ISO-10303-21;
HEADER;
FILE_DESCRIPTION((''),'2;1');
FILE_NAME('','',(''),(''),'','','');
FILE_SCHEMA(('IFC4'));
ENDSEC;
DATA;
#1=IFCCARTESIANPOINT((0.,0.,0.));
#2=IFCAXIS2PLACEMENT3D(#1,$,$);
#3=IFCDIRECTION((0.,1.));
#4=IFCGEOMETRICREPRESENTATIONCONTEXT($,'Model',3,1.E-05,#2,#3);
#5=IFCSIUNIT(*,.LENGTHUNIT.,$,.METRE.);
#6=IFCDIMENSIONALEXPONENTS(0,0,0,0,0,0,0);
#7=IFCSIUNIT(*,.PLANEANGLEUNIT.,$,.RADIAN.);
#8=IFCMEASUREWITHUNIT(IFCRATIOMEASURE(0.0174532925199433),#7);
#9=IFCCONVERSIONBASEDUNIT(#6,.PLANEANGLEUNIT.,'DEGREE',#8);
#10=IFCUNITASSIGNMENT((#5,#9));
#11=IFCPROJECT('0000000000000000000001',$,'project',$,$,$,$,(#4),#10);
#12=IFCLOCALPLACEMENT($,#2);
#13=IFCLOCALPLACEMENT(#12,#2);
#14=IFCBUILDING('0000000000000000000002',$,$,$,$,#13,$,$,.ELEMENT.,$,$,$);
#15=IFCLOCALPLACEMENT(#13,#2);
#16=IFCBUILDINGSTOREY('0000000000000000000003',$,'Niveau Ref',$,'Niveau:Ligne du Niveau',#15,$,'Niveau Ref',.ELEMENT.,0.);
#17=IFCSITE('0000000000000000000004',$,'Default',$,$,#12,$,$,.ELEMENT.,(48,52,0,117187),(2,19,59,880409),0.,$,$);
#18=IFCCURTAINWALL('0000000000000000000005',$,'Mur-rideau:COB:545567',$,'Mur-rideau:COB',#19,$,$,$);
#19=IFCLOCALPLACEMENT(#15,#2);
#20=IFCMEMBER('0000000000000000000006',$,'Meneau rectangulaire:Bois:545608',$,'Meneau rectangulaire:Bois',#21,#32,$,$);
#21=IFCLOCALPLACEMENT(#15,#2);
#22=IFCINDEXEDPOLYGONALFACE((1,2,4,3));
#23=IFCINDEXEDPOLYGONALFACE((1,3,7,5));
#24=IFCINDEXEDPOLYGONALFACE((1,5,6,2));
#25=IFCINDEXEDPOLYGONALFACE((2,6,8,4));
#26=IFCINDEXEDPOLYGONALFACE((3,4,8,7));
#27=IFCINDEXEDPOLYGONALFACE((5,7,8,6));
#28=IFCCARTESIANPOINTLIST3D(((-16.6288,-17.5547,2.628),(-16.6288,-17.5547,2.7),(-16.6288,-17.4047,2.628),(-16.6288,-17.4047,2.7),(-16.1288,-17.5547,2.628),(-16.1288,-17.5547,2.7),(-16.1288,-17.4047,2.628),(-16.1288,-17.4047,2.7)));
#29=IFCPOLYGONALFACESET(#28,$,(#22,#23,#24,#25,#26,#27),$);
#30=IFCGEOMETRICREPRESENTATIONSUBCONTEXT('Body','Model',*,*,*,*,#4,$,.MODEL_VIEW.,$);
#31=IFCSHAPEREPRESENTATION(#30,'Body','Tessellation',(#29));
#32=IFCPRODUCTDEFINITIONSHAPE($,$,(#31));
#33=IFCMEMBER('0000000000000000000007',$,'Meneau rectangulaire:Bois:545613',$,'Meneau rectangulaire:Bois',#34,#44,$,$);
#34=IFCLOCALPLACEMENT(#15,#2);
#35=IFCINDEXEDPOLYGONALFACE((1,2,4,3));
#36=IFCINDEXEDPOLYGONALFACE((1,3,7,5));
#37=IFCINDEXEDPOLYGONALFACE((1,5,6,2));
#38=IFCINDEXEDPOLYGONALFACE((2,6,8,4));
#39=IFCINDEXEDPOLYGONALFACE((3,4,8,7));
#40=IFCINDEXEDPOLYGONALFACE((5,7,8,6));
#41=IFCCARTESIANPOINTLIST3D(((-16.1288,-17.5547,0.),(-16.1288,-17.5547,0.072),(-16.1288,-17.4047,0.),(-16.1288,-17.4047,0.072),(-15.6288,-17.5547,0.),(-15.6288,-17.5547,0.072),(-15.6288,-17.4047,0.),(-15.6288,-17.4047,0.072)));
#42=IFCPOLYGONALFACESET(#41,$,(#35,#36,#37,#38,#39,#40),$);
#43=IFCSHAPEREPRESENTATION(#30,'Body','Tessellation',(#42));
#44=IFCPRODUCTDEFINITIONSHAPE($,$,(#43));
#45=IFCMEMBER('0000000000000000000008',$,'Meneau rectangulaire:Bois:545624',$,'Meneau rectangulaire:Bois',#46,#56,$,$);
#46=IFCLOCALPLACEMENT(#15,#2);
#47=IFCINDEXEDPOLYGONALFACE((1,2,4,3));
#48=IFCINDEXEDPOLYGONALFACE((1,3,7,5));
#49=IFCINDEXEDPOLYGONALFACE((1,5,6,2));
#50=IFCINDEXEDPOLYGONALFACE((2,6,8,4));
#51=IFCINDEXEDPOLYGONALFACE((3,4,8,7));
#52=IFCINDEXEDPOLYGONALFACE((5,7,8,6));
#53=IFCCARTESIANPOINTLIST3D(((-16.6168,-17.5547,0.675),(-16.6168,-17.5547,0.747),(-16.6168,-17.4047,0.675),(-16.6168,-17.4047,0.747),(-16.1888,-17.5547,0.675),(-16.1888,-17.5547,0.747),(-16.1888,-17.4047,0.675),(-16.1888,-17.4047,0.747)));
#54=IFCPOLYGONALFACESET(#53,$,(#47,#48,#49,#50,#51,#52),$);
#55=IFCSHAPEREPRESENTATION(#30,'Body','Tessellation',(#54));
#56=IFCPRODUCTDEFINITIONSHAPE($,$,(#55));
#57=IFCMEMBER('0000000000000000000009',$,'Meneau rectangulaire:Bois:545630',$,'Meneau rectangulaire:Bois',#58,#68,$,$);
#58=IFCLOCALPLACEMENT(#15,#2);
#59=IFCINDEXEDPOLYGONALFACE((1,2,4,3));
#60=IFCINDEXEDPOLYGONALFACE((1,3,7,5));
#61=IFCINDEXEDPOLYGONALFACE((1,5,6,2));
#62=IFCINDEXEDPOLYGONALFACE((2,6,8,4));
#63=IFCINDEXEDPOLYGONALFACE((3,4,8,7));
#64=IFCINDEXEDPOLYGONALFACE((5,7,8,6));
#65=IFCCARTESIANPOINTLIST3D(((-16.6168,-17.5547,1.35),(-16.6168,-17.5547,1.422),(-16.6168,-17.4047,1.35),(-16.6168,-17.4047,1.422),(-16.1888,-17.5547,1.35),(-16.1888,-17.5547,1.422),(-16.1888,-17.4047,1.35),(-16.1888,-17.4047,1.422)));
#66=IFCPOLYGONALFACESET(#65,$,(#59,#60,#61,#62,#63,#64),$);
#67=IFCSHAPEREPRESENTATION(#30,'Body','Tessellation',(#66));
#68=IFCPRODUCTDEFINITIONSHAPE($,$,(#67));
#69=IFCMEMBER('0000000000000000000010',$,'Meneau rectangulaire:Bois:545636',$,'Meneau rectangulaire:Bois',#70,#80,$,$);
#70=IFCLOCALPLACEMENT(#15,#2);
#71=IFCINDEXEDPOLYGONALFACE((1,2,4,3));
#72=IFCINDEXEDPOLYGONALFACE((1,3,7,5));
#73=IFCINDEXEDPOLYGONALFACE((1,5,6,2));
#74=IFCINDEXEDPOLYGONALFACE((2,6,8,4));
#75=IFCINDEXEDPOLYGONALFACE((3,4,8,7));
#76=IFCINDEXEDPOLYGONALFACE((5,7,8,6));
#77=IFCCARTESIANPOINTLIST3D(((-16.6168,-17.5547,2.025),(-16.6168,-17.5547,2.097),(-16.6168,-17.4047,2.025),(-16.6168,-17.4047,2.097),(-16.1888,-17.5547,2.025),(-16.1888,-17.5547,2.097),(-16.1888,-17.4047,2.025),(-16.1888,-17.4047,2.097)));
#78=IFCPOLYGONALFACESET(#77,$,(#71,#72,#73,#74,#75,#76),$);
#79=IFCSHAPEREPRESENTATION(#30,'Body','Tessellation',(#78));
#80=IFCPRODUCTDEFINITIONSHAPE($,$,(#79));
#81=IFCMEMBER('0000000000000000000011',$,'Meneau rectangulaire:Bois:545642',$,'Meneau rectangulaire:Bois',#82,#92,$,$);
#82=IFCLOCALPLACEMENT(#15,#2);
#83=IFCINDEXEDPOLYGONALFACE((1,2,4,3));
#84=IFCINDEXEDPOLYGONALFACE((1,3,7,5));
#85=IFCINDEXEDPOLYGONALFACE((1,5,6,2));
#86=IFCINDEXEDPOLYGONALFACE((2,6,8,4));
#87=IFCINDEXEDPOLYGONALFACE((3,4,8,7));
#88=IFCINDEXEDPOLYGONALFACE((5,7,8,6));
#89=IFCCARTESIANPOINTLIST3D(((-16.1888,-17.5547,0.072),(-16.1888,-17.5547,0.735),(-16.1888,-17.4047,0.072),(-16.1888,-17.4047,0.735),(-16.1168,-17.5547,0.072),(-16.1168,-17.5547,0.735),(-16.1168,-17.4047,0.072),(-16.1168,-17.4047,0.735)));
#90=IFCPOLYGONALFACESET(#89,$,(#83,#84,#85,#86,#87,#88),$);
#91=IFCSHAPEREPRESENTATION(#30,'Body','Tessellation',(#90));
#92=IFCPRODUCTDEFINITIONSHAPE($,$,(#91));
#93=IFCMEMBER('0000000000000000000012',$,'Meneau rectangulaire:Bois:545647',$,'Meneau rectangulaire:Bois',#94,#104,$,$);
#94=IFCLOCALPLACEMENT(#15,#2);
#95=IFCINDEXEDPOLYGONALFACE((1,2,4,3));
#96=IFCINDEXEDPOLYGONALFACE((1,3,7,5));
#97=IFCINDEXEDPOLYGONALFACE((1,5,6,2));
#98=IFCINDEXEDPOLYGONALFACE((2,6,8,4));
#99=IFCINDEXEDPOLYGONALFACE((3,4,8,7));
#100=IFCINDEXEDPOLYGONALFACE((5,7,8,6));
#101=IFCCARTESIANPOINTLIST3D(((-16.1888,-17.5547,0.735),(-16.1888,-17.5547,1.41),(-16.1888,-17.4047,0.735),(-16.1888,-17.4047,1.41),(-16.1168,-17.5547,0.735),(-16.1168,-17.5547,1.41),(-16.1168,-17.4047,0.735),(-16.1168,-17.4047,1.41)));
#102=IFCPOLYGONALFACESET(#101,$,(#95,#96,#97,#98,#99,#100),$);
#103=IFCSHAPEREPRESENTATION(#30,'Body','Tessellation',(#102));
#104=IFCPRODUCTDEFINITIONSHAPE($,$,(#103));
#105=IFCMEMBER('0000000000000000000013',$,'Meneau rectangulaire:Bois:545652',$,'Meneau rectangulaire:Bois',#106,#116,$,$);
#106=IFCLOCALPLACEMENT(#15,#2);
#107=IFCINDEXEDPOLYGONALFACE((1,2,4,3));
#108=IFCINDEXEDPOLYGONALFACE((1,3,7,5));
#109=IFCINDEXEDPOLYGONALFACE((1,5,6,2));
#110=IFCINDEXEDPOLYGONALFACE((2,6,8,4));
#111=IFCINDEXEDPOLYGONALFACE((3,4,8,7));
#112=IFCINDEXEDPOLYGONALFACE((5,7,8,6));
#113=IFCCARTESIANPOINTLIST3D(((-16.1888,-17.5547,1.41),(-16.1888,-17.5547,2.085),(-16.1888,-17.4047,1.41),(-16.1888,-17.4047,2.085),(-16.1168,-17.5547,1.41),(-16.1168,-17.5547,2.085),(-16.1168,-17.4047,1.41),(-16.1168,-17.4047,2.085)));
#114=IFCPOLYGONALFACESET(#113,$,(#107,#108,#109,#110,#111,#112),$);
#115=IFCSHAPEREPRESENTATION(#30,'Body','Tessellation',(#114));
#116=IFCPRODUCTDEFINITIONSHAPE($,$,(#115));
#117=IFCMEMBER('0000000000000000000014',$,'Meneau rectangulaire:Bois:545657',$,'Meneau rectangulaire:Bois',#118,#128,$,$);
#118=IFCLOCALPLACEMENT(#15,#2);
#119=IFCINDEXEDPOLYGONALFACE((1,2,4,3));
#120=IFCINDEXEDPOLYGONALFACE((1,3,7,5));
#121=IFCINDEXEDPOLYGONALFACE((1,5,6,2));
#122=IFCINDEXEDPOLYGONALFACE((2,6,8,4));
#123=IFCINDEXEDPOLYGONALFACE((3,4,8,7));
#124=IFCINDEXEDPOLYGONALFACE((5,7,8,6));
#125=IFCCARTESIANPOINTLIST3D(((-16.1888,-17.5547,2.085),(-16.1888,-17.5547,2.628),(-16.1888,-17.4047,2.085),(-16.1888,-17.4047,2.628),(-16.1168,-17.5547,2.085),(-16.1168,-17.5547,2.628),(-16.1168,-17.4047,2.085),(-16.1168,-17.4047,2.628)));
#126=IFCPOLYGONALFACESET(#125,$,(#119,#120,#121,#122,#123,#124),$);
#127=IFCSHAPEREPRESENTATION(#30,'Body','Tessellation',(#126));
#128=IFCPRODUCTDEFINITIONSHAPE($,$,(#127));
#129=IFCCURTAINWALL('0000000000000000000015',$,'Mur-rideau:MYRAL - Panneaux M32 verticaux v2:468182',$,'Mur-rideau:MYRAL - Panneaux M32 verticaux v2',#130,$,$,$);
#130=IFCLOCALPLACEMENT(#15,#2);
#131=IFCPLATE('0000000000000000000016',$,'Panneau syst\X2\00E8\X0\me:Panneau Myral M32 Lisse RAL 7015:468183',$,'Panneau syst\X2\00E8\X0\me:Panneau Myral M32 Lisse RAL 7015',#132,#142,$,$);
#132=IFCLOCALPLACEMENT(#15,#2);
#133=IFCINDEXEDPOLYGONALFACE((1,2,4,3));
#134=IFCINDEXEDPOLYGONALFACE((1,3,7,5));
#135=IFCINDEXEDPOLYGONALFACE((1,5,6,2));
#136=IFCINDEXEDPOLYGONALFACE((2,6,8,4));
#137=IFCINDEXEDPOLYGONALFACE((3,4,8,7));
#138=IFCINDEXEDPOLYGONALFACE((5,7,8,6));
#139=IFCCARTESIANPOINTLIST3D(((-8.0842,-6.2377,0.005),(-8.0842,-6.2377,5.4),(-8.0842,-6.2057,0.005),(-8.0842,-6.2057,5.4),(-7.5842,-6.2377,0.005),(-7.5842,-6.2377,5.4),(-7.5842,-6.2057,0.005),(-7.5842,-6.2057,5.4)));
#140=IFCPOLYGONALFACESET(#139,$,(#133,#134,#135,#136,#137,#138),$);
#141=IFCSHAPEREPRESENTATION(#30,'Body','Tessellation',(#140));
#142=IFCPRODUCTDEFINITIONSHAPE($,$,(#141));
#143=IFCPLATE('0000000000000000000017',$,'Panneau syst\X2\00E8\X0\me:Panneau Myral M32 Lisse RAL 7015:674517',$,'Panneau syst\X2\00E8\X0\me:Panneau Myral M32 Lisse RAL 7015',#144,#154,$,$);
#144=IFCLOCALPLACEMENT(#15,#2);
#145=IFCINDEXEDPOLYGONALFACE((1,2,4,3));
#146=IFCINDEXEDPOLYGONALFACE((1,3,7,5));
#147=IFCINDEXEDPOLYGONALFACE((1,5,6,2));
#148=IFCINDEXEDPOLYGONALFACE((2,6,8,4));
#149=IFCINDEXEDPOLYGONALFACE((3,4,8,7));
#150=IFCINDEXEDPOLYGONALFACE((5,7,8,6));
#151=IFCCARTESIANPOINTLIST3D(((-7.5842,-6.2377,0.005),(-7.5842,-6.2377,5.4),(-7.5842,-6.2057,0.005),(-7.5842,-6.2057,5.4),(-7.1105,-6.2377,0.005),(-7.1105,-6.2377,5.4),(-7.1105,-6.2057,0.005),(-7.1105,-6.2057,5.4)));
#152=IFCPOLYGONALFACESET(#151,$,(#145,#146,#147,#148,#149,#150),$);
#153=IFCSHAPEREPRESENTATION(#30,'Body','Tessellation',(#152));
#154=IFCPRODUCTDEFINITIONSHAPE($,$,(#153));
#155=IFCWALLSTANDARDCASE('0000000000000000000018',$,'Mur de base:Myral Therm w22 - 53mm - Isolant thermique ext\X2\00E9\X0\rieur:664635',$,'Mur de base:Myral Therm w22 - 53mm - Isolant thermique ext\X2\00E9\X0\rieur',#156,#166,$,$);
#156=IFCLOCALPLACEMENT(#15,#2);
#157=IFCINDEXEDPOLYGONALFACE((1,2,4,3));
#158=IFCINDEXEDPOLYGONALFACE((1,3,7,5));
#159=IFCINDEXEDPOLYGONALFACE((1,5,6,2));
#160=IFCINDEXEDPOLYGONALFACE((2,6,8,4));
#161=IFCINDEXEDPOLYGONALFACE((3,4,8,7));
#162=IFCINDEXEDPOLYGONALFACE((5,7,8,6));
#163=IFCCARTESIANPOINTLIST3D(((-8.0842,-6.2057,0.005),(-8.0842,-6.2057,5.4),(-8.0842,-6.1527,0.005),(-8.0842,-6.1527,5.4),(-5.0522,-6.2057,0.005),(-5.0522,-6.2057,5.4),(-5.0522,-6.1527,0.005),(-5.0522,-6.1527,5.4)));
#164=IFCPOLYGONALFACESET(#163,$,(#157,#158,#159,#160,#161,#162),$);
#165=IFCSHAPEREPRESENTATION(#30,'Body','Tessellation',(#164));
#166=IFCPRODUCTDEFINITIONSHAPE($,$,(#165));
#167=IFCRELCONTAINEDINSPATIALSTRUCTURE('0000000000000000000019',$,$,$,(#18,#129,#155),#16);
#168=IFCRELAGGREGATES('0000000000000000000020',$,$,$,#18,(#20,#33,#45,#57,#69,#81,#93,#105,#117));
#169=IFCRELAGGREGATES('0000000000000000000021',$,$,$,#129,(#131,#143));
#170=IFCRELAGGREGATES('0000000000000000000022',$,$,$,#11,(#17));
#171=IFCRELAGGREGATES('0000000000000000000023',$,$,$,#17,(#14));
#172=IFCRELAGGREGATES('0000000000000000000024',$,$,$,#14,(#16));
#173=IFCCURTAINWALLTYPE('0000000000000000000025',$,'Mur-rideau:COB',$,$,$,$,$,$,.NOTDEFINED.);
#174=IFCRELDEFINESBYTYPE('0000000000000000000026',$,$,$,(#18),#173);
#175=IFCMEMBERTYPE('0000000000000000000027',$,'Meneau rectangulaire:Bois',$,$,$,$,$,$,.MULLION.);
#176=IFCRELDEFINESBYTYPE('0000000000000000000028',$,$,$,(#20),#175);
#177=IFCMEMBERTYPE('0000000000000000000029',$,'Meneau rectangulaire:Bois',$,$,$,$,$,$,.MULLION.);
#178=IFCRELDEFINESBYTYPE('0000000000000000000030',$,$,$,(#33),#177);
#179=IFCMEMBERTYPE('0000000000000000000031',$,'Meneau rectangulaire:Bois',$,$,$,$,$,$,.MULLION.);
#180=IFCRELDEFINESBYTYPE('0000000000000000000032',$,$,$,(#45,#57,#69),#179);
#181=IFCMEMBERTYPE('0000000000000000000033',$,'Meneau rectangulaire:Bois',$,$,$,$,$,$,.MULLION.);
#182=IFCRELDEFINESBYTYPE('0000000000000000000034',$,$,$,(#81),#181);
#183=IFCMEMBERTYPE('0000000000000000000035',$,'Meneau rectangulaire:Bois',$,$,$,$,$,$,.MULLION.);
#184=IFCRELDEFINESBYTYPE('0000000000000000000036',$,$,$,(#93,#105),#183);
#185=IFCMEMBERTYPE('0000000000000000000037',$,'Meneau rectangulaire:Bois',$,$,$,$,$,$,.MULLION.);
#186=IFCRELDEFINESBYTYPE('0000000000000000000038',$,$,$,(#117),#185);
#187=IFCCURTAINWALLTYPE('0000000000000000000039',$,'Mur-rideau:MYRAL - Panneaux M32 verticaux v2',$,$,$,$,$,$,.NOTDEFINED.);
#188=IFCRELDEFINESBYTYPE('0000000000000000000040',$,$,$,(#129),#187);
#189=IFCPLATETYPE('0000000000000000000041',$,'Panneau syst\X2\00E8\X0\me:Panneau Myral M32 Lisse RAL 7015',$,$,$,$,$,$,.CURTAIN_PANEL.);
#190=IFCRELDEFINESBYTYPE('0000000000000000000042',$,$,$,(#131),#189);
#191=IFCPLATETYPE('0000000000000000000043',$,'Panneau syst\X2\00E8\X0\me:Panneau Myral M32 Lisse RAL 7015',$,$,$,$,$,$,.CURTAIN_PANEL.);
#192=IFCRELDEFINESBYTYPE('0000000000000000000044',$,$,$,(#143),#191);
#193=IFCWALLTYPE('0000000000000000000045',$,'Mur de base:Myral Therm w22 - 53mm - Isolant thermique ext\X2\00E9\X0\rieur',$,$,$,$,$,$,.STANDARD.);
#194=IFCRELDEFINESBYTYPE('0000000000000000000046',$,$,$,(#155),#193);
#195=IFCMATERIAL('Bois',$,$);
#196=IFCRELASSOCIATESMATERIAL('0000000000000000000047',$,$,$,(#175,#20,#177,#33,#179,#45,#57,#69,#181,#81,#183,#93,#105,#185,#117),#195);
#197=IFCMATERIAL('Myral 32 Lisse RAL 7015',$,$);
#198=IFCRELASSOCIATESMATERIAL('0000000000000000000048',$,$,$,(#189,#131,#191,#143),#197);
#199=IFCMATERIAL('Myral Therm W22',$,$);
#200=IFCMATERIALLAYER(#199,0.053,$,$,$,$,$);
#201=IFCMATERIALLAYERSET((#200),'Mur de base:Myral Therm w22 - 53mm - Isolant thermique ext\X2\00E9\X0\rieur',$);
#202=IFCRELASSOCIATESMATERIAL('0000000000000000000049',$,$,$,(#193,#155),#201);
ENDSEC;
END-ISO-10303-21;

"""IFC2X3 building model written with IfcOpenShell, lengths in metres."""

from ifc_helpers import new_model, entity, si_unit, converted_unit, direction, frame, frame_2d, origin, origin_2d_with_axis, place, context, subcontext, project, spatial, rectangle, extrude, source, transform, mapped, material, layer, layer_set, layer_usage, type_object, type_shapes, element, aggregate, save


model = new_model("IFC2X3")

# Units and contexts
model_context = context("Model", 3, precision=1e-05, world=origin(), true_north=direction((0.0, 1.0)))
body_context = subcontext(model_context, "Body", "Model", "MODEL_VIEW")
ifc_project = project(units=[si_unit("LENGTHUNIT", "METRE"), converted_unit("PLANEANGLEUNIT", "DEGREE", entity("IfcRatioMeasure", 0.0174532925199433), si_unit("PLANEANGLEUNIT", "RADIAN"), dimensions=[0, 0, 0, 0, 0, 0, 0])], contexts=[model_context])

# Site, building, storey
site_placement = place(None, origin())
site = spatial("IfcSite", under=ifc_project, at=site_placement, Name="Default", CompositionType="ELEMENT", RefLatitude=(48, 52, 0, 117187), RefLongitude=(2, 19, 59, 880409), RefElevation=0.0)
building_placement = place(site_placement, origin())
building = spatial("IfcBuilding", under=site, at=building_placement, CompositionType="ELEMENT")
storey_placement = place(building_placement, origin())
storey = spatial("IfcBuildingStorey", under=building, at=storey_placement, Name="Niveau Ref", ObjectType="Niveau:Ligne du Niveau", LongName="Niveau Ref", CompositionType="ELEMENT", Elevation=0.0)

# Curtain wall, members
curtain_wall_type_1 = type_object("IfcCurtainWallType", Name="Mur-rideau:COB", PredefinedType="NOTDEFINED")
curtain_wall_1_placement = place(storey_placement, origin())
curtain_wall_1 = element("IfcCurtainWall", 1, at=curtain_wall_1_placement, inside=storey, type_object=curtain_wall_type_1, Name="Mur-rideau:COB:545567", ObjectType="Mur-rideau:COB")
ifc_material_1 = material(Name="Bois")
member_type_1 = type_object("IfcMemberType", Name="Meneau rectangulaire:Bois", PredefinedType="MULLION", material=ifc_material_1)
shared_shape_1 = source(origin(), body_context, "Body", "SweptSolid", [
    extrude(rectangle(XDim=0.15, YDim=0.072, at=origin_2d_with_axis()), frame((-0.036, 0.0, -0.5), z_axis=(0.0, 0.0, 1.0), x_axis=(0.0, -1.0, 0.0)), (0.0, 0.0, 1.0), 0.5),
])
type_shapes(member_type_1, [shared_shape_1])
member_1_placement = place(storey_placement, frame((-16.1288, -17.4797, 2.7), z_axis=(1.0, 0.0, 0.0), x_axis=(0.0, 0.0, 1.0)))
member_1 = element("IfcMember", 2, at=member_1_placement, type_object=member_type_1, material=ifc_material_1, Name="Meneau rectangulaire:Bois:545608", ObjectType="Meneau rectangulaire:Bois", context=body_context, shape_type="MappedRepresentation", body=[
    mapped(shared_shape_1, transform((0.0, 0.0, 0.0), scale=1.0)),
])
member_type_2 = type_object("IfcMemberType", Name="Meneau rectangulaire:Bois", PredefinedType="MULLION", material=ifc_material_1)
shared_shape_2 = source(origin(), body_context, "Body", "SweptSolid", [
    extrude(rectangle(XDim=0.15, YDim=0.072, at=origin_2d_with_axis()), frame((-0.036, 0.0, -0.5), z_axis=(0.0, 0.0, 1.0), x_axis=(0.0, -1.0, 0.0)), (0.0, 0.0, 1.0), 0.5),
])
type_shapes(member_type_2, [shared_shape_2])
member_2_placement = place(storey_placement, frame((-16.1288, -17.4797, 0.0), z_axis=(-1.0, 0.0, 0.0), x_axis=(0.0, 0.0, -1.0)))
member_2 = element("IfcMember", 3, at=member_2_placement, type_object=member_type_2, material=ifc_material_1, Name="Meneau rectangulaire:Bois:545613", ObjectType="Meneau rectangulaire:Bois", context=body_context, shape_type="MappedRepresentation", body=[
    mapped(shared_shape_2, transform((0.0, 0.0, 0.0), scale=1.0)),
])
member_type_3 = type_object("IfcMemberType", Name="Meneau rectangulaire:Bois", PredefinedType="MULLION", material=ifc_material_1)
shared_shape_3 = source(origin(), body_context, "Body", "SweptSolid", [
    extrude(rectangle(XDim=0.15, YDim=0.072, at=origin_2d_with_axis()), frame((-0.024, 0.0, -0.428), z_axis=(0.0, 0.0, 1.0), x_axis=(0.0, -1.0, 0.0)), (0.0, 0.0, 1.0), 0.428),
])
type_shapes(member_type_3, [shared_shape_3])
member_3_placement = place(storey_placement, frame((-16.1888, -17.4797, 0.735), z_axis=(1.0, 0.0, 0.0), x_axis=(0.0, 0.0, 1.0)))
member_3 = element("IfcMember", 4, at=member_3_placement, type_object=member_type_3, material=ifc_material_1, Name="Meneau rectangulaire:Bois:545624", ObjectType="Meneau rectangulaire:Bois", context=body_context, shape_type="MappedRepresentation", body=[
    mapped(shared_shape_3, transform((0.0, 0.0, 0.0), scale=1.0)),
])
member_4_placement = place(storey_placement, frame((-16.1888, -17.4797, 1.41), z_axis=(1.0, 0.0, 0.0), x_axis=(0.0, 0.0, 1.0)))
member_4 = element("IfcMember", 5, at=member_4_placement, type_object=member_type_3, material=ifc_material_1, Name="Meneau rectangulaire:Bois:545630", ObjectType="Meneau rectangulaire:Bois", context=body_context, shape_type="MappedRepresentation", body=[
    mapped(shared_shape_3, transform((0.0, 0.0, 0.0), scale=1.0)),
])
member_5_placement = place(storey_placement, frame((-16.1888, -17.4797, 2.085), z_axis=(1.0, 0.0, 0.0), x_axis=(0.0, 0.0, 1.0)))
member_5 = element("IfcMember", 6, at=member_5_placement, type_object=member_type_3, material=ifc_material_1, Name="Meneau rectangulaire:Bois:545636", ObjectType="Meneau rectangulaire:Bois", context=body_context, shape_type="MappedRepresentation", body=[
    mapped(shared_shape_3, transform((0.0, 0.0, 0.0), scale=1.0)),
])
member_type_4 = type_object("IfcMemberType", Name="Meneau rectangulaire:Bois", PredefinedType="MULLION", material=ifc_material_1)
shared_shape_4 = source(origin(), body_context, "Body", "SweptSolid", [
    extrude(rectangle(XDim=0.15, YDim=0.072, at=origin_2d_with_axis()), frame((-0.024, 0.0, -0.663), z_axis=(0.0, 0.0, 1.0), x_axis=(0.0, -1.0, 0.0)), (0.0, 0.0, 1.0), 0.663),
])
type_shapes(member_type_4, [shared_shape_4])
member_6_placement = place(storey_placement, frame((-16.1288, -17.4797, 0.072), z_axis=(0.0, 0.0, -1.0), x_axis=(1.0, 0.0, 0.0)))
member_6 = element("IfcMember", 7, at=member_6_placement, type_object=member_type_4, material=ifc_material_1, Name="Meneau rectangulaire:Bois:545642", ObjectType="Meneau rectangulaire:Bois", context=body_context, shape_type="MappedRepresentation", body=[
    mapped(shared_shape_4, transform((0.0, 0.0, 0.0), scale=1.0)),
])
member_type_5 = type_object("IfcMemberType", Name="Meneau rectangulaire:Bois", PredefinedType="MULLION", material=ifc_material_1)
shared_shape_5 = source(origin(), body_context, "Body", "SweptSolid", [
    extrude(rectangle(XDim=0.15, YDim=0.072, at=origin_2d_with_axis()), frame((-0.024, 0.0, -0.675), z_axis=(0.0, 0.0, 1.0), x_axis=(0.0, -1.0, 0.0)), (0.0, 0.0, 1.0), 0.675),
])
type_shapes(member_type_5, [shared_shape_5])
member_7_placement = place(storey_placement, frame((-16.1288, -17.4797, 0.735), z_axis=(0.0, 0.0, -1.0), x_axis=(1.0, 0.0, 0.0)))
member_7 = element("IfcMember", 8, at=member_7_placement, type_object=member_type_5, material=ifc_material_1, Name="Meneau rectangulaire:Bois:545647", ObjectType="Meneau rectangulaire:Bois", context=body_context, shape_type="MappedRepresentation", body=[
    mapped(shared_shape_5, transform((0.0, 0.0, 0.0), scale=1.0)),
])
member_8_placement = place(storey_placement, frame((-16.1288, -17.4797, 1.41), z_axis=(0.0, 0.0, -1.0), x_axis=(1.0, 0.0, 0.0)))
member_8 = element("IfcMember", 9, at=member_8_placement, type_object=member_type_5, material=ifc_material_1, Name="Meneau rectangulaire:Bois:545652", ObjectType="Meneau rectangulaire:Bois", context=body_context, shape_type="MappedRepresentation", body=[
    mapped(shared_shape_5, transform((0.0, 0.0, 0.0), scale=1.0)),
])
member_type_6 = type_object("IfcMemberType", Name="Meneau rectangulaire:Bois", PredefinedType="MULLION", material=ifc_material_1)
shared_shape_6 = source(origin(), body_context, "Body", "SweptSolid", [
    extrude(rectangle(XDim=0.15, YDim=0.072, at=origin_2d_with_axis()), frame((-0.024, 0.0, -0.543), z_axis=(0.0, 0.0, 1.0), x_axis=(0.0, -1.0, 0.0)), (0.0, 0.0, 1.0), 0.543),
])
type_shapes(member_type_6, [shared_shape_6])
member_9_placement = place(storey_placement, frame((-16.1288, -17.4797, 2.085), z_axis=(0.0, 0.0, -1.0), x_axis=(1.0, 0.0, 0.0)))
member_9 = element("IfcMember", 10, at=member_9_placement, type_object=member_type_6, material=ifc_material_1, Name="Meneau rectangulaire:Bois:545657", ObjectType="Meneau rectangulaire:Bois", context=body_context, shape_type="MappedRepresentation", body=[
    mapped(shared_shape_6, transform((0.0, 0.0, 0.0), scale=1.0)),
])
aggregate(curtain_wall_1, [member_1, member_2, member_3, member_4, member_5, member_6, member_7, member_8, member_9])

# Curtain wall, plates
curtain_wall_type_2 = type_object("IfcCurtainWallType", Name="Mur-rideau:MYRAL - Panneaux M32 verticaux v2", PredefinedType="NOTDEFINED")
curtain_wall_2_placement = place(storey_placement, origin())
curtain_wall_2 = element("IfcCurtainWall", 11, at=curtain_wall_2_placement, inside=storey, type_object=curtain_wall_type_2, Name="Mur-rideau:MYRAL - Panneaux M32 verticaux v2:468182", ObjectType="Mur-rideau:MYRAL - Panneaux M32 verticaux v2")
ifc_material_2 = material(Name="Myral 32 Lisse RAL 7015")
plate_type_1 = type_object("IfcPlateType", Name="Panneau système:Panneau Myral M32 Lisse RAL 7015", PredefinedType="CURTAIN_PANEL", material=ifc_material_2)
shared_shape_7 = source(origin(), body_context, "Body", "SweptSolid", [
    extrude(rectangle(XDim=0.032, YDim=0.5, at=origin_2d_with_axis()), frame((0.0, -0.016, 0.0), z_axis=(0.0, 0.0, 1.0), x_axis=(0.0, 1.0, 0.0)), (0.0, 0.0, 1.0), 5.395),
])
type_shapes(plate_type_1, [shared_shape_7])
plate_1_placement = place(curtain_wall_2_placement, frame((-7.8342, -6.2057, 0.005)))
plate_1 = element("IfcPlate", 12, at=plate_1_placement, type_object=plate_type_1, material=ifc_material_2, Name="Panneau système:Panneau Myral M32 Lisse RAL 7015:468183", ObjectType="Panneau système:Panneau Myral M32 Lisse RAL 7015", context=body_context, shape_type="MappedRepresentation", body=[
    mapped(shared_shape_7, transform((0.0, 0.0, 0.0), scale=1.0)),
])
plate_type_2 = type_object("IfcPlateType", Name="Panneau système:Panneau Myral M32 Lisse RAL 7015", PredefinedType="CURTAIN_PANEL", material=ifc_material_2)
shared_shape_8 = source(origin(), body_context, "Body", "SweptSolid", [
    extrude(rectangle(XDim=0.032, YDim=0.4737, at=origin_2d_with_axis()), frame((0.0, -0.016, 0.0), z_axis=(0.0, 0.0, 1.0), x_axis=(0.0, 1.0, 0.0)), (0.0, 0.0, 1.0), 5.395),
])
type_shapes(plate_type_2, [shared_shape_8])
plate_2_placement = place(curtain_wall_2_placement, frame((-7.3474, -6.2057, 0.005)))
plate_2 = element("IfcPlate", 13, at=plate_2_placement, type_object=plate_type_2, material=ifc_material_2, Name="Panneau système:Panneau Myral M32 Lisse RAL 7015:674517", ObjectType="Panneau système:Panneau Myral M32 Lisse RAL 7015", context=body_context, shape_type="MappedRepresentation", body=[
    mapped(shared_shape_8, transform((0.0, 0.0, 0.0), scale=1.0)),
])
aggregate(curtain_wall_2, [plate_1, plate_2])

# Wall
ifc_material_3 = material(Name="Myral Therm W22")
ifc_layer = layer(ifc_material_3, 0.053)
ifc_layer_set = layer_set([ifc_layer], Name="Mur de base:Myral Therm w22 - 53mm - Isolant thermique extérieur")
ifc_layer_usage = layer_usage(ifc_layer_set, "AXIS2", "NEGATIVE", 0.0265)
wall_type = type_object("IfcWallType", Name="Mur de base:Myral Therm w22 - 53mm - Isolant thermique extérieur", PredefinedType="STANDARD", material=ifc_layer_set)
wall_placement = place(storey_placement, frame((-8.0842, -6.1792, 0.005)))
element("IfcWallStandardCase", 14, at=wall_placement, inside=storey, type_object=wall_type, material=ifc_layer_usage, Name="Mur de base:Myral Therm w22 - 53mm - Isolant thermique extérieur:664635", ObjectType="Mur de base:Myral Therm w22 - 53mm - Isolant thermique extérieur", context=body_context, shape_type="SweptSolid", body=[
    extrude(rectangle(XDim=3.032, YDim=0.053, at=frame_2d((1.516, 0.0), x_axis=(-1.0, 0.0))), origin(), (0.0, 0.0, 1.0), 5.395),
])

save(model, "model.ifc")
